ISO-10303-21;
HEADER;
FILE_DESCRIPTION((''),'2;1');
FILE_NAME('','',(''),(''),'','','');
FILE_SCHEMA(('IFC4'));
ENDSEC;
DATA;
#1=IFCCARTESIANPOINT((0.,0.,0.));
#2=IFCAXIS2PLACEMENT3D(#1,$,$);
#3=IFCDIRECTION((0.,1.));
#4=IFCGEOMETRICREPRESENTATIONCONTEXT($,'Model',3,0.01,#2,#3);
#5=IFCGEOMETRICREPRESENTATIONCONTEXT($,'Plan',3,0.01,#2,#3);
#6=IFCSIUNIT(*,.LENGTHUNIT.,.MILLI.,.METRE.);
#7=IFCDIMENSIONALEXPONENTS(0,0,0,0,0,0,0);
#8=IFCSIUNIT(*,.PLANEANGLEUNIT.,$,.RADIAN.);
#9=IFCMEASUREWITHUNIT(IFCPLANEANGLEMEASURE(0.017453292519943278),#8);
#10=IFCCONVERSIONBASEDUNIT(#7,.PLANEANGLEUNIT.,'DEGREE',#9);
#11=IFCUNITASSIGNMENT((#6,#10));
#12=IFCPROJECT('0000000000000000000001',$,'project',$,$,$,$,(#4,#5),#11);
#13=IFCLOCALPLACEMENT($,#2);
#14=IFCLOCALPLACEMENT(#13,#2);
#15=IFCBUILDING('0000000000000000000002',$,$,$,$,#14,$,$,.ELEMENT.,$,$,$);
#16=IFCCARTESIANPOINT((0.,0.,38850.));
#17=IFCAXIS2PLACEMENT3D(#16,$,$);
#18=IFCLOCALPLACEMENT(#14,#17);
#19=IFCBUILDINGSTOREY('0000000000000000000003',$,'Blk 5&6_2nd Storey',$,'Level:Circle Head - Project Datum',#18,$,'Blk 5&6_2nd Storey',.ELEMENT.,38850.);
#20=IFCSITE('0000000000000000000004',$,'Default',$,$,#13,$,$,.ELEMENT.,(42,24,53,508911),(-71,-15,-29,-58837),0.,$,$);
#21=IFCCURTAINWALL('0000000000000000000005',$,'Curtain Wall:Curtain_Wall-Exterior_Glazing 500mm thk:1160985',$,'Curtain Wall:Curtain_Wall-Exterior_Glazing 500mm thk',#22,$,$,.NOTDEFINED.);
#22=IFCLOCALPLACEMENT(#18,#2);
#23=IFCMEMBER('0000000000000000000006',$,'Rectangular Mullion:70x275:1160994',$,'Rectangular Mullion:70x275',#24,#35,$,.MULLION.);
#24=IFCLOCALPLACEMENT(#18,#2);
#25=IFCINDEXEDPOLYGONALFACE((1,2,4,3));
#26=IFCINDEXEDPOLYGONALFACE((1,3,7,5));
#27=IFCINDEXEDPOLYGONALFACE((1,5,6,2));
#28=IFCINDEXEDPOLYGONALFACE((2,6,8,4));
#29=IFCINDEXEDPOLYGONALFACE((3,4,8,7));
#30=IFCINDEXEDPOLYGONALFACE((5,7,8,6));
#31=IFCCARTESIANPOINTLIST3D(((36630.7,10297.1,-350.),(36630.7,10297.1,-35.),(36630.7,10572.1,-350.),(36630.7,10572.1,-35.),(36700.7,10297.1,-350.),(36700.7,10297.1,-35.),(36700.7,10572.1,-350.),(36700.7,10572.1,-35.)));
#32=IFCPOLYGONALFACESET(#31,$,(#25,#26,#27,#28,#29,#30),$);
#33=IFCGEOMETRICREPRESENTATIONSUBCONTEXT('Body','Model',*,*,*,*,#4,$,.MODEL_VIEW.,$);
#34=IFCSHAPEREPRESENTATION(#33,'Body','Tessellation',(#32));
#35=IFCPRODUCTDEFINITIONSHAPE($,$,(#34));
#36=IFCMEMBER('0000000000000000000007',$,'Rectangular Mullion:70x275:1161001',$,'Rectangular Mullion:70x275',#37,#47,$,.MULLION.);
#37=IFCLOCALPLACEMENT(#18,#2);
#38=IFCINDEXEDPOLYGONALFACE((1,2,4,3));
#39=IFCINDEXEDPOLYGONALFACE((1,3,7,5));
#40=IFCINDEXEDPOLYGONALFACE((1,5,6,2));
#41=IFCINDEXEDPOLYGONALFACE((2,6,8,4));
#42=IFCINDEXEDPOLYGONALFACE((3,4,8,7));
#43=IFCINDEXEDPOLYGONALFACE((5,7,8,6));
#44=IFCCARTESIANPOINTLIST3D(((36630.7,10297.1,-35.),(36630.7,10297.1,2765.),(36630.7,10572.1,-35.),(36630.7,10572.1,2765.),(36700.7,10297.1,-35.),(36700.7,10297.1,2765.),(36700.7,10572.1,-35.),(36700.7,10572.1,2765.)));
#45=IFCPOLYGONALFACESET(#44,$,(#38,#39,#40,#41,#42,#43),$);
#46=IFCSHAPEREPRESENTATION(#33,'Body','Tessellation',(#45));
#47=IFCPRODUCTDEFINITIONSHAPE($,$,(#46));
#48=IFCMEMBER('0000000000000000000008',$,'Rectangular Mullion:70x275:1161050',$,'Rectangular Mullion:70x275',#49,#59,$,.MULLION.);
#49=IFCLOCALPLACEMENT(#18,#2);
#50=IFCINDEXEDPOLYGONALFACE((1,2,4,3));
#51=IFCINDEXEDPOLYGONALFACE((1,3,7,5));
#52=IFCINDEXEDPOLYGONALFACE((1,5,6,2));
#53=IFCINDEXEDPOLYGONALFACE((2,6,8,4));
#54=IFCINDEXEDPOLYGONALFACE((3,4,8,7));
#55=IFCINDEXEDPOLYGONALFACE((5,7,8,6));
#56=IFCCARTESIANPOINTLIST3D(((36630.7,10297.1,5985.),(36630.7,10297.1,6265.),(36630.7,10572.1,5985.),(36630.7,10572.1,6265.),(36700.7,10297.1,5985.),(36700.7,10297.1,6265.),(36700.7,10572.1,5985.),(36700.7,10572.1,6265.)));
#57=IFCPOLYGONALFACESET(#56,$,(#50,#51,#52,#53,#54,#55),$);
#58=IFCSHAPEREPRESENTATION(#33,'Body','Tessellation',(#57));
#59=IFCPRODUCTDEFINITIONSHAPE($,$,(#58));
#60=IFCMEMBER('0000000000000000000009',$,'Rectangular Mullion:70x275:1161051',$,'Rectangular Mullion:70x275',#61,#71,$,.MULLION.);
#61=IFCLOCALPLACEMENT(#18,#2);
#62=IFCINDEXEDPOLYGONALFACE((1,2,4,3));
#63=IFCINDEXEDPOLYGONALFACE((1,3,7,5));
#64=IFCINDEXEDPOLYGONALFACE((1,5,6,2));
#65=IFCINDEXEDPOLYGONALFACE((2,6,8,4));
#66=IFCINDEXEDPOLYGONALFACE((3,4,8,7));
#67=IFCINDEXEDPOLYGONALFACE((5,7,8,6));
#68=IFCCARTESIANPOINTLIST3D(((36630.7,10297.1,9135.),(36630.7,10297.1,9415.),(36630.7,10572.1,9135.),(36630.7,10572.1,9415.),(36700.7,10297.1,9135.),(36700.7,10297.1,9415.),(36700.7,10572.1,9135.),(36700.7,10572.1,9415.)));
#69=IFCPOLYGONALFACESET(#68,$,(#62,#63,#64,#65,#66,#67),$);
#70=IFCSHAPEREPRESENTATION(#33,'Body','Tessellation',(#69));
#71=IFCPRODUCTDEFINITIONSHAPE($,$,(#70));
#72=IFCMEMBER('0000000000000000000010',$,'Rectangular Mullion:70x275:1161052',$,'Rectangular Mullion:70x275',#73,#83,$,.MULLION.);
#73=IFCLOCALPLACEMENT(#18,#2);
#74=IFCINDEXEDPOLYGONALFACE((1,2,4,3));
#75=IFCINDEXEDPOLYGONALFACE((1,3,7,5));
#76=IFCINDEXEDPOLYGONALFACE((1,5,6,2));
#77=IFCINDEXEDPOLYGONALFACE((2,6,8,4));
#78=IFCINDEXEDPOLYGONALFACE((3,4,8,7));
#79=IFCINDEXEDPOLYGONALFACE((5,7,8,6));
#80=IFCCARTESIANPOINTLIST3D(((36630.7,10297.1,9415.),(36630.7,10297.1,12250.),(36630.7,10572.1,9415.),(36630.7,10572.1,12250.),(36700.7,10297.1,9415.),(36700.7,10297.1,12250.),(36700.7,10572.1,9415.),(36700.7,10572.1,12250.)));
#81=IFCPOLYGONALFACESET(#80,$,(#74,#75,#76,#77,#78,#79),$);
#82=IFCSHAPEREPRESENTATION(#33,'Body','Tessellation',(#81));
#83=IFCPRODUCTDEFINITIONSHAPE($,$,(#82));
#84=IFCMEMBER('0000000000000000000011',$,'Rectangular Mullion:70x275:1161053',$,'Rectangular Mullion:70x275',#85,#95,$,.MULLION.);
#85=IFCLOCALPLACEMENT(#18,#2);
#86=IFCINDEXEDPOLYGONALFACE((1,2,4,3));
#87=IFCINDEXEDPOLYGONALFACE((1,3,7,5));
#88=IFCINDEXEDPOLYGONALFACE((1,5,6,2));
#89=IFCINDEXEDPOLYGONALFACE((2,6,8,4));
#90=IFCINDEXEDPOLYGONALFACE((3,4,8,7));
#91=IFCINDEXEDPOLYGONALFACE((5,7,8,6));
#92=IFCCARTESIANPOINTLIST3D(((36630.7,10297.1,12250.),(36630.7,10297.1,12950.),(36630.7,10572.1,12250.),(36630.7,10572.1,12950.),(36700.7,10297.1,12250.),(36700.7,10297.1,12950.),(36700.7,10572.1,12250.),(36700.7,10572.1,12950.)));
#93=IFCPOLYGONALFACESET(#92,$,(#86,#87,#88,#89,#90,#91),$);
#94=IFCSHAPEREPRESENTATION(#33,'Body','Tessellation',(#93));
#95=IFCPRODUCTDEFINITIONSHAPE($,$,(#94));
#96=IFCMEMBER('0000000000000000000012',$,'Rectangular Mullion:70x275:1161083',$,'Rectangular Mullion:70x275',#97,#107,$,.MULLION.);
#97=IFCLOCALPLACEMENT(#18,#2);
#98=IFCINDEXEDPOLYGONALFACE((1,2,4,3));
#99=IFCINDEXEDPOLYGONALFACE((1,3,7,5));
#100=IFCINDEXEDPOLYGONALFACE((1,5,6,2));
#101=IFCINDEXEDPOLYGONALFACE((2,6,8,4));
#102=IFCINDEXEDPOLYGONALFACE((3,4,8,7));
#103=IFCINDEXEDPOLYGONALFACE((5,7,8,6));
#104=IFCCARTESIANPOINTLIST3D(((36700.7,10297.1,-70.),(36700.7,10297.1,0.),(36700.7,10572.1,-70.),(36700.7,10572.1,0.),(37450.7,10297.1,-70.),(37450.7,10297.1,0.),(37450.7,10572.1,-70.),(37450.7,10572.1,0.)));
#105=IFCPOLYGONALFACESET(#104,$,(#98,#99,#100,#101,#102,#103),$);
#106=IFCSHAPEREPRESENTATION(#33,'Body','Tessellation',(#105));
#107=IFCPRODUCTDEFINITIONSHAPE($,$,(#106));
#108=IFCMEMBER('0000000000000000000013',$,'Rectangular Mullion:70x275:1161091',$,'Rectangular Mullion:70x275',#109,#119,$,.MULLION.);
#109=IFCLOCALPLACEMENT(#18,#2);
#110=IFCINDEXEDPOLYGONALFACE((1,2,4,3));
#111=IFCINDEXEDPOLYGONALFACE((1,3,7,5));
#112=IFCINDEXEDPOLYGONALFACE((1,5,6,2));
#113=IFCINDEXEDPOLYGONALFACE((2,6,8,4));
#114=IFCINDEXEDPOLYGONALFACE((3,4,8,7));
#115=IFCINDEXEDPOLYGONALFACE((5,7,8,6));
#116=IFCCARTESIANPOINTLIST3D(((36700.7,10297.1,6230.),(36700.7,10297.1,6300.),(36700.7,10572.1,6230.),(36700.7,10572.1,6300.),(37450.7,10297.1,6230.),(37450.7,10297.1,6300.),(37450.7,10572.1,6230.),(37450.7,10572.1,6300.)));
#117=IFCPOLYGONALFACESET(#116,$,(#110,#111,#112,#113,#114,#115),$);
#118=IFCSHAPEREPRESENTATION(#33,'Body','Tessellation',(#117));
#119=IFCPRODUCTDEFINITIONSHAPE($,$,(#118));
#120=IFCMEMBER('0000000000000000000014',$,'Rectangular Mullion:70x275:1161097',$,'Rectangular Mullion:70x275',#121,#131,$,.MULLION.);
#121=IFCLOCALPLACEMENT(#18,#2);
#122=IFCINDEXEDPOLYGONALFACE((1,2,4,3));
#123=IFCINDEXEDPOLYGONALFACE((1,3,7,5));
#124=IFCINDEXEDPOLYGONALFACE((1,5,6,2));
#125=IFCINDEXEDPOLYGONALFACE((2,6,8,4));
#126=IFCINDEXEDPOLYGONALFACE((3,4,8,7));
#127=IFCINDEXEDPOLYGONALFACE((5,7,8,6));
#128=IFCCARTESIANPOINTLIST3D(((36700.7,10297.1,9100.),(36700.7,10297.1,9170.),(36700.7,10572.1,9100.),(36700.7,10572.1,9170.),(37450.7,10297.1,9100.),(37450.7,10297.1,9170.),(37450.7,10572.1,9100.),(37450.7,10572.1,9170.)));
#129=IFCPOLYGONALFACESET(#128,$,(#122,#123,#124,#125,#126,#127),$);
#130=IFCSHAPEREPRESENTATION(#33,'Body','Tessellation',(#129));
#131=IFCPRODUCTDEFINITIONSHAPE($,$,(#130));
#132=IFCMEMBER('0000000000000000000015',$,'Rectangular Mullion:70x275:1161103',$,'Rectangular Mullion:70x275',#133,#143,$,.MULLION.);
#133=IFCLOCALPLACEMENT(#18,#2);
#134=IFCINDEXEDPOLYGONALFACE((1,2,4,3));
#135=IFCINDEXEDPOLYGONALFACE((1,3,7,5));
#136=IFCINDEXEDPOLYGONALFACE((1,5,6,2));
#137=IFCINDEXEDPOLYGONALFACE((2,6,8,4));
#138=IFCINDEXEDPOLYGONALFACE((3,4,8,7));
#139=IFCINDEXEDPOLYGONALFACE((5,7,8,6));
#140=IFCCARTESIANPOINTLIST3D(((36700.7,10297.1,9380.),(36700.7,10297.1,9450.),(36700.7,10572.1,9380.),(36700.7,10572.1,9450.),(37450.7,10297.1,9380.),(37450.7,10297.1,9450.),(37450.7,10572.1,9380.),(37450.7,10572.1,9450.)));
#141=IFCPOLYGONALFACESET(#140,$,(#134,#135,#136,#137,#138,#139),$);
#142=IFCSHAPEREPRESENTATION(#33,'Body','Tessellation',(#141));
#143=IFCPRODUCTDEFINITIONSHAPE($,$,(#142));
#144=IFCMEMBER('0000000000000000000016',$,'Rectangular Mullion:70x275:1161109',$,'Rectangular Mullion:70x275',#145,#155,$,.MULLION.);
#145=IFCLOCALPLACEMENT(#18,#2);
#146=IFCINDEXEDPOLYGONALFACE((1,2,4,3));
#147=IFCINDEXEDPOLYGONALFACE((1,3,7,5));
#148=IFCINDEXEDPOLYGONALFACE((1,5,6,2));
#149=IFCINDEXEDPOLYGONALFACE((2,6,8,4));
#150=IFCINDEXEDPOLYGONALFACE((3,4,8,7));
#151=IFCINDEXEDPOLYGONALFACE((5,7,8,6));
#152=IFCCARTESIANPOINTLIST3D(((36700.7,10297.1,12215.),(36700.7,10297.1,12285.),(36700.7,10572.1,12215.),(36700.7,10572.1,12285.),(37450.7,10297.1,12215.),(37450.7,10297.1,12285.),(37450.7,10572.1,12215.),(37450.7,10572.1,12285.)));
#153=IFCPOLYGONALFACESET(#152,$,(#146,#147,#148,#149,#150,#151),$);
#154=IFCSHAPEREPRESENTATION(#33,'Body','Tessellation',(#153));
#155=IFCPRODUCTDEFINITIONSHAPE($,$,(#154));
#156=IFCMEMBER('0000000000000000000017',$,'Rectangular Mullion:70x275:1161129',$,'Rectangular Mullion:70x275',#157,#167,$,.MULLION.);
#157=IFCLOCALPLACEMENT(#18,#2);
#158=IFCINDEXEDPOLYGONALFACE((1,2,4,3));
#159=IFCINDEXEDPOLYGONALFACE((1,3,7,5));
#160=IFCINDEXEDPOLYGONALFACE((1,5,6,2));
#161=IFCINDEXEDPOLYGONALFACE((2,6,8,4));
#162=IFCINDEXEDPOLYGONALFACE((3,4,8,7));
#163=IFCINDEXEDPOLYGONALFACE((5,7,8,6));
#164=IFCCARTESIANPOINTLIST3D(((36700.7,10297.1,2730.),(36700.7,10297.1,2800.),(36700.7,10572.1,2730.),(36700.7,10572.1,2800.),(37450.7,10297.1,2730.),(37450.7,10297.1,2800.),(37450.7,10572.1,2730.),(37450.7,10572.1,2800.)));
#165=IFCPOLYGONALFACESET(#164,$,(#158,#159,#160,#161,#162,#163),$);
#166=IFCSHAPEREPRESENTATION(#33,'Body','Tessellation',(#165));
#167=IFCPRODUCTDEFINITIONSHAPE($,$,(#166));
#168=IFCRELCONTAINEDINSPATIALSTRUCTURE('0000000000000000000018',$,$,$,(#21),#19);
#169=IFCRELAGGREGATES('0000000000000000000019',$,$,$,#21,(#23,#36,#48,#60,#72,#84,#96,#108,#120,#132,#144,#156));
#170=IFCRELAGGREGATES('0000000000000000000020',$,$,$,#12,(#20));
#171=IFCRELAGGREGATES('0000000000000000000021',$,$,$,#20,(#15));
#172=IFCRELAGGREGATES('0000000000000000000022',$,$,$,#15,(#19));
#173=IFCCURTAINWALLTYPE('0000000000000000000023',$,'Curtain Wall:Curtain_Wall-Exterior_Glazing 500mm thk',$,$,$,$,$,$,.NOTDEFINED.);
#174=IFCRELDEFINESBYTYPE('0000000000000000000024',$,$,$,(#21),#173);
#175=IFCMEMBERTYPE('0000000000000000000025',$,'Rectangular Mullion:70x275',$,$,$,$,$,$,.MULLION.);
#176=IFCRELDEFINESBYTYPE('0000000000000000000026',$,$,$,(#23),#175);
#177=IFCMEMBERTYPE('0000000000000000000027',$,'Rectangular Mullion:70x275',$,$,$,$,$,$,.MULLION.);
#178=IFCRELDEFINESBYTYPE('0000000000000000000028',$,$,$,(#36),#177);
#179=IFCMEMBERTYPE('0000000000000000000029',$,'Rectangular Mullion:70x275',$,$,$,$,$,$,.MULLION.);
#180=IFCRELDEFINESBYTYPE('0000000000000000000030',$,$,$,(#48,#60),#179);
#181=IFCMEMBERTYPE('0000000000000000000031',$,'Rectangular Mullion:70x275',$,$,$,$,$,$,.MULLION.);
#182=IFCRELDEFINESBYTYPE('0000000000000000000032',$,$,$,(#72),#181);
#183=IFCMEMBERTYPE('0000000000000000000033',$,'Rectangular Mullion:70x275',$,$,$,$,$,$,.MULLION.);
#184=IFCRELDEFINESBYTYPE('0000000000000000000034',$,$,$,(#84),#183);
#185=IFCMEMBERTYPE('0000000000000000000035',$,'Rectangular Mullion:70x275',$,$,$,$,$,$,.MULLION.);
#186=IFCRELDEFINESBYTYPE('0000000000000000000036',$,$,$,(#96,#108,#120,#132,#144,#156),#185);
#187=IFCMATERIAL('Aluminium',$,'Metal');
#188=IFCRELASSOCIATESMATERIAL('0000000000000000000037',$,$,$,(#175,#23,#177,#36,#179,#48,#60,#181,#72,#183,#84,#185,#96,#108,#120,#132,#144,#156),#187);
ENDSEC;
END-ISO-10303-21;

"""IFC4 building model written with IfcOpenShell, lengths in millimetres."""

from ifc_helpers import new_model, entity, si_unit, converted_unit, direction, frame, origin, place, context, subcontext, project, spatial, indexed_curve, outline, extrude, source, transform, mapped, material, type_object, type_shapes, element, aggregate, save


model = new_model("IFC4")

# Units and contexts
model_context = context("Model", 3, precision=0.01, world=origin(), true_north=direction((0.0, 1.0)))
plan_context = context("Plan", 3, precision=0.01, world=origin(), true_north=direction((0.0, 1.0)))
body_context = subcontext(model_context, "Body", "Model", "MODEL_VIEW")
ifc_project = project(units=[si_unit("LENGTHUNIT", "METRE", prefix="MILLI"), converted_unit("PLANEANGLEUNIT", "DEGREE", entity("IfcPlaneAngleMeasure", 0.017453292519943278), si_unit("PLANEANGLEUNIT", "RADIAN"), dimensions=[0, 0, 0, 0, 0, 0, 0])], contexts=[model_context, plan_context])

# Site, building, storey
site_placement = place(None, origin())
site = spatial("IfcSite", under=ifc_project, at=site_placement, Name="Default", CompositionType="ELEMENT", RefLatitude=(42, 24, 53, 508911), RefLongitude=(-71, -15, -29, -58837), RefElevation=0.0)
building_placement = place(site_placement, origin())
building = spatial("IfcBuilding", under=site, at=building_placement, CompositionType="ELEMENT")
storey_placement = place(building_placement, frame((0.0, 0.0, 38850.0)))
storey = spatial("IfcBuildingStorey", under=building, at=storey_placement, Name="Blk 5&6_2nd Storey", ObjectType="Level:Circle Head - Project Datum", LongName="Blk 5&6_2nd Storey", CompositionType="ELEMENT", Elevation=38850.0)

# Curtain wall, members
curtain_wall_type = type_object("IfcCurtainWallType", Name="Curtain Wall:Curtain_Wall-Exterior_Glazing 500mm thk", PredefinedType="NOTDEFINED")
curtain_wall_placement = place(storey_placement, frame((0.0, 0.0, -38850.0)))
curtain_wall = element("IfcCurtainWall", 1, at=curtain_wall_placement, inside=storey, type_object=curtain_wall_type, Name="Curtain Wall:Curtain_Wall-Exterior_Glazing 500mm thk:1160985", ObjectType="Curtain Wall:Curtain_Wall-Exterior_Glazing 500mm thk", PredefinedType="NOTDEFINED")
ifc_material_1 = material(Name="Aluminium", Category="Metal")
member_type_1 = type_object("IfcMemberType", Name="Rectangular Mullion:70x275", PredefinedType="MULLION", material=ifc_material_1)
shared_shape_1 = source(origin(), body_context, "Body", "SweptSolid", [
    extrude(outline(indexed_curve([(-35.0, -137.5), (35.0, -137.5), (35.0, 137.5), (-35.0, 137.5), (-35.0, -137.5)], self_intersect=False)), frame((-35.0, -137.5, -315.0), z_axis=(0.0, 0.0, 1.0), x_axis=(-1.0, 0.0, 0.0)), (0.0, 0.0, 1.0), 315.0),
])
type_shapes(member_type_1, [shared_shape_1])
member_1_placement = place(curtain_wall_placement, frame((36630.7, 10572.1, 38500.0), z_axis=(0.0, 0.0, -1.0), x_axis=(-1.0, 0.0, 0.0)))
member_1 = element("IfcMember", 2, at=member_1_placement, type_object=member_type_1, material=ifc_material_1, Name="Rectangular Mullion:70x275:1160994", ObjectType="Rectangular Mullion:70x275", PredefinedType="MULLION", context=body_context, shape_type="MappedRepresentation", body=[
    mapped(shared_shape_1, transform((0.0, 0.0, 0.0), scale=1.0)),
])
member_type_2 = type_object("IfcMemberType", Name="Rectangular Mullion:70x275", PredefinedType="MULLION", material=ifc_material_1)
shared_shape_2 = source(origin(), body_context, "Body", "SweptSolid", [
    extrude(outline(indexed_curve([(-35.0, -137.5), (35.0, -137.5), (35.0, 137.5), (-35.0, 137.5), (-35.0, -137.5)], self_intersect=False)), frame((-35.0, -137.5, -2800.0), z_axis=(0.0, 0.0, 1.0), x_axis=(-1.0, 0.0, 0.0)), (0.0, 0.0, 1.0), 2800.0),
])
type_shapes(member_type_2, [shared_shape_2])
member_2_placement = place(curtain_wall_placement, frame((36630.7, 10572.1, 38815.0), z_axis=(0.0, 0.0, -1.0), x_axis=(-1.0, 0.0, 0.0)))
member_2 = element("IfcMember", 3, at=member_2_placement, type_object=member_type_2, material=ifc_material_1, Name="Rectangular Mullion:70x275:1161001", ObjectType="Rectangular Mullion:70x275", PredefinedType="MULLION", context=body_context, shape_type="MappedRepresentation", body=[
    mapped(shared_shape_2, transform((0.0, 0.0, 0.0), scale=1.0)),
])
member_type_3 = type_object("IfcMemberType", Name="Rectangular Mullion:70x275", PredefinedType="MULLION", material=ifc_material_1)
shared_shape_3 = source(origin(), body_context, "Body", "SweptSolid", [
    extrude(outline(indexed_curve([(-35.0, -137.5), (35.0, -137.5), (35.0, 137.5), (-35.0, 137.5), (-35.0, -137.5)], self_intersect=False)), frame((-35.0, -137.5, -280.0), z_axis=(0.0, 0.0, 1.0), x_axis=(-1.0, 0.0, 0.0)), (0.0, 0.0, 1.0), 280.0),
])
type_shapes(member_type_3, [shared_shape_3])
member_3_placement = place(curtain_wall_placement, frame((36630.7, 10572.1, 44835.0), z_axis=(0.0, 0.0, -1.0), x_axis=(-1.0, 0.0, 0.0)))
member_3 = element("IfcMember", 4, at=member_3_placement, type_object=member_type_3, material=ifc_material_1, Name="Rectangular Mullion:70x275:1161050", ObjectType="Rectangular Mullion:70x275", PredefinedType="MULLION", context=body_context, shape_type="MappedRepresentation", body=[
    mapped(shared_shape_3, transform((0.0, 0.0, 0.0), scale=1.0)),
])
member_4_placement = place(curtain_wall_placement, frame((36630.7, 10572.1, 47985.0), z_axis=(0.0, 0.0, -1.0), x_axis=(-1.0, 0.0, 0.0)))
member_4 = element("IfcMember", 5, at=member_4_placement, type_object=member_type_3, material=ifc_material_1, Name="Rectangular Mullion:70x275:1161051", ObjectType="Rectangular Mullion:70x275", PredefinedType="MULLION", context=body_context, shape_type="MappedRepresentation", body=[
    mapped(shared_shape_3, transform((0.0, 0.0, 0.0), scale=1.0)),
])
member_type_4 = type_object("IfcMemberType", Name="Rectangular Mullion:70x275", PredefinedType="MULLION", material=ifc_material_1)
shared_shape_4 = source(origin(), body_context, "Body", "SweptSolid", [
    extrude(outline(indexed_curve([(-35.0, -137.5), (35.0, -137.5), (35.0, 137.5), (-35.0, 137.5), (-35.0, -137.5)], self_intersect=False)), frame((-35.0, -137.5, -2835.0), z_axis=(0.0, 0.0, 1.0), x_axis=(-1.0, 0.0, 0.0)), (0.0, 0.0, 1.0), 2835.0),
])
type_shapes(member_type_4, [shared_shape_4])
member_5_placement = place(curtain_wall_placement, frame((36630.7, 10572.1, 48265.0), z_axis=(0.0, 0.0, -1.0), x_axis=(-1.0, 0.0, 0.0)))
member_5 = element("IfcMember", 6, at=member_5_placement, type_object=member_type_4, material=ifc_material_1, Name="Rectangular Mullion:70x275:1161052", ObjectType="Rectangular Mullion:70x275", PredefinedType="MULLION", context=body_context, shape_type="MappedRepresentation", body=[
    mapped(shared_shape_4, transform((0.0, 0.0, 0.0), scale=1.0)),
])
member_type_5 = type_object("IfcMemberType", Name="Rectangular Mullion:70x275", PredefinedType="MULLION", material=ifc_material_1)
shared_shape_5 = source(origin(), body_context, "Body", "SweptSolid", [
    extrude(outline(indexed_curve([(-35.0, -137.5), (35.0, -137.5), (35.0, 137.5), (-35.0, 137.5), (-35.0, -137.5)], self_intersect=False)), frame((-35.0, -137.5, -700.0), z_axis=(0.0, 0.0, 1.0), x_axis=(-1.0, 0.0, 0.0)), (0.0, 0.0, 1.0), 700.0),
])
type_shapes(member_type_5, [shared_shape_5])
member_6_placement = place(curtain_wall_placement, frame((36630.7, 10572.1, 51100.0), z_axis=(0.0, 0.0, -1.0), x_axis=(-1.0, 0.0, 0.0)))
member_6 = element("IfcMember", 7, at=member_6_placement, type_object=member_type_5, material=ifc_material_1, Name="Rectangular Mullion:70x275:1161053", ObjectType="Rectangular Mullion:70x275", PredefinedType="MULLION", context=body_context, shape_type="MappedRepresentation", body=[
    mapped(shared_shape_5, transform((0.0, 0.0, 0.0), scale=1.0)),
])
member_type_6 = type_object("IfcMemberType", Name="Rectangular Mullion:70x275", PredefinedType="MULLION", material=ifc_material_1)
shared_shape_6 = source(origin(), body_context, "Body", "SweptSolid", [
    extrude(outline(indexed_curve([(-35.0, -137.5), (35.0, -137.5), (35.0, 137.5), (-35.0, 137.5), (-35.0, -137.5)], self_intersect=False)), frame((0.0, -137.5, -750.0), z_axis=(0.0, 0.0, 1.0), x_axis=(-1.0, 0.0, 0.0)), (0.0, 0.0, 1.0), 750.0),
])
type_shapes(member_type_6, [shared_shape_6])
member_7_placement = place(curtain_wall_placement, frame((36700.7, 10572.1, 38815.0), z_axis=(-1.0, 0.0, 0.0), x_axis=(0.0, 0.0, 1.0)))
member_7 = element("IfcMember", 8, at=member_7_placement, type_object=member_type_6, material=ifc_material_1, Name="Rectangular Mullion:70x275:1161083", ObjectType="Rectangular Mullion:70x275", PredefinedType="MULLION", context=body_context, shape_type="MappedRepresentation", body=[
    mapped(shared_shape_6, transform((0.0, 0.0, 0.0), scale=1.0)),
])
member_8_placement = place(curtain_wall_placement, frame((36700.7, 10572.1, 45115.0), z_axis=(-1.0, 0.0, 0.0), x_axis=(0.0, 0.0, 1.0)))
member_8 = element("IfcMember", 9, at=member_8_placement, type_object=member_type_6, material=ifc_material_1, Name="Rectangular Mullion:70x275:1161091", ObjectType="Rectangular Mullion:70x275", PredefinedType="MULLION", context=body_context, shape_type="MappedRepresentation", body=[
    mapped(shared_shape_6, transform((0.0, 0.0, 0.0), scale=1.0)),
])
member_9_placement = place(curtain_wall_placement, frame((36700.7, 10572.1, 47985.0), z_axis=(-1.0, 0.0, 0.0), x_axis=(0.0, 0.0, 1.0)))
member_9 = element("IfcMember", 10, at=member_9_placement, type_object=member_type_6, material=ifc_material_1, Name="Rectangular Mullion:70x275:1161097", ObjectType="Rectangular Mullion:70x275", PredefinedType="MULLION", context=body_context, shape_type="MappedRepresentation", body=[
    mapped(shared_shape_6, transform((0.0, 0.0, 0.0), scale=1.0)),
])
member_10_placement = place(curtain_wall_placement, frame((36700.7, 10572.1, 48265.0), z_axis=(-1.0, 0.0, 0.0), x_axis=(0.0, 0.0, 1.0)))
member_10 = element("IfcMember", 11, at=member_10_placement, type_object=member_type_6, material=ifc_material_1, Name="Rectangular Mullion:70x275:1161103", ObjectType="Rectangular Mullion:70x275", PredefinedType="MULLION", context=body_context, shape_type="MappedRepresentation", body=[
    mapped(shared_shape_6, transform((0.0, 0.0, 0.0), scale=1.0)),
])
member_11_placement = place(curtain_wall_placement, frame((36700.7, 10572.1, 51100.0), z_axis=(-1.0, 0.0, 0.0), x_axis=(0.0, 0.0, 1.0)))
member_11 = element("IfcMember", 12, at=member_11_placement, type_object=member_type_6, material=ifc_material_1, Name="Rectangular Mullion:70x275:1161109", ObjectType="Rectangular Mullion:70x275", PredefinedType="MULLION", context=body_context, shape_type="MappedRepresentation", body=[
    mapped(shared_shape_6, transform((0.0, 0.0, 0.0), scale=1.0)),
])
member_12_placement = place(curtain_wall_placement, frame((36700.7, 10572.1, 41615.0), z_axis=(-1.0, 0.0, 0.0), x_axis=(0.0, 0.0, 1.0)))
member_12 = element("IfcMember", 13, at=member_12_placement, type_object=member_type_6, material=ifc_material_1, Name="Rectangular Mullion:70x275:1161129", ObjectType="Rectangular Mullion:70x275", PredefinedType="MULLION", context=body_context, shape_type="MappedRepresentation", body=[
    mapped(shared_shape_6, transform((0.0, 0.0, 0.0), scale=1.0)),
])
aggregate(curtain_wall, [member_1, member_2, member_3, member_4, member_5, member_6, member_7, member_8, member_9, member_10, member_11, member_12])

save(model, "model.ifc")
